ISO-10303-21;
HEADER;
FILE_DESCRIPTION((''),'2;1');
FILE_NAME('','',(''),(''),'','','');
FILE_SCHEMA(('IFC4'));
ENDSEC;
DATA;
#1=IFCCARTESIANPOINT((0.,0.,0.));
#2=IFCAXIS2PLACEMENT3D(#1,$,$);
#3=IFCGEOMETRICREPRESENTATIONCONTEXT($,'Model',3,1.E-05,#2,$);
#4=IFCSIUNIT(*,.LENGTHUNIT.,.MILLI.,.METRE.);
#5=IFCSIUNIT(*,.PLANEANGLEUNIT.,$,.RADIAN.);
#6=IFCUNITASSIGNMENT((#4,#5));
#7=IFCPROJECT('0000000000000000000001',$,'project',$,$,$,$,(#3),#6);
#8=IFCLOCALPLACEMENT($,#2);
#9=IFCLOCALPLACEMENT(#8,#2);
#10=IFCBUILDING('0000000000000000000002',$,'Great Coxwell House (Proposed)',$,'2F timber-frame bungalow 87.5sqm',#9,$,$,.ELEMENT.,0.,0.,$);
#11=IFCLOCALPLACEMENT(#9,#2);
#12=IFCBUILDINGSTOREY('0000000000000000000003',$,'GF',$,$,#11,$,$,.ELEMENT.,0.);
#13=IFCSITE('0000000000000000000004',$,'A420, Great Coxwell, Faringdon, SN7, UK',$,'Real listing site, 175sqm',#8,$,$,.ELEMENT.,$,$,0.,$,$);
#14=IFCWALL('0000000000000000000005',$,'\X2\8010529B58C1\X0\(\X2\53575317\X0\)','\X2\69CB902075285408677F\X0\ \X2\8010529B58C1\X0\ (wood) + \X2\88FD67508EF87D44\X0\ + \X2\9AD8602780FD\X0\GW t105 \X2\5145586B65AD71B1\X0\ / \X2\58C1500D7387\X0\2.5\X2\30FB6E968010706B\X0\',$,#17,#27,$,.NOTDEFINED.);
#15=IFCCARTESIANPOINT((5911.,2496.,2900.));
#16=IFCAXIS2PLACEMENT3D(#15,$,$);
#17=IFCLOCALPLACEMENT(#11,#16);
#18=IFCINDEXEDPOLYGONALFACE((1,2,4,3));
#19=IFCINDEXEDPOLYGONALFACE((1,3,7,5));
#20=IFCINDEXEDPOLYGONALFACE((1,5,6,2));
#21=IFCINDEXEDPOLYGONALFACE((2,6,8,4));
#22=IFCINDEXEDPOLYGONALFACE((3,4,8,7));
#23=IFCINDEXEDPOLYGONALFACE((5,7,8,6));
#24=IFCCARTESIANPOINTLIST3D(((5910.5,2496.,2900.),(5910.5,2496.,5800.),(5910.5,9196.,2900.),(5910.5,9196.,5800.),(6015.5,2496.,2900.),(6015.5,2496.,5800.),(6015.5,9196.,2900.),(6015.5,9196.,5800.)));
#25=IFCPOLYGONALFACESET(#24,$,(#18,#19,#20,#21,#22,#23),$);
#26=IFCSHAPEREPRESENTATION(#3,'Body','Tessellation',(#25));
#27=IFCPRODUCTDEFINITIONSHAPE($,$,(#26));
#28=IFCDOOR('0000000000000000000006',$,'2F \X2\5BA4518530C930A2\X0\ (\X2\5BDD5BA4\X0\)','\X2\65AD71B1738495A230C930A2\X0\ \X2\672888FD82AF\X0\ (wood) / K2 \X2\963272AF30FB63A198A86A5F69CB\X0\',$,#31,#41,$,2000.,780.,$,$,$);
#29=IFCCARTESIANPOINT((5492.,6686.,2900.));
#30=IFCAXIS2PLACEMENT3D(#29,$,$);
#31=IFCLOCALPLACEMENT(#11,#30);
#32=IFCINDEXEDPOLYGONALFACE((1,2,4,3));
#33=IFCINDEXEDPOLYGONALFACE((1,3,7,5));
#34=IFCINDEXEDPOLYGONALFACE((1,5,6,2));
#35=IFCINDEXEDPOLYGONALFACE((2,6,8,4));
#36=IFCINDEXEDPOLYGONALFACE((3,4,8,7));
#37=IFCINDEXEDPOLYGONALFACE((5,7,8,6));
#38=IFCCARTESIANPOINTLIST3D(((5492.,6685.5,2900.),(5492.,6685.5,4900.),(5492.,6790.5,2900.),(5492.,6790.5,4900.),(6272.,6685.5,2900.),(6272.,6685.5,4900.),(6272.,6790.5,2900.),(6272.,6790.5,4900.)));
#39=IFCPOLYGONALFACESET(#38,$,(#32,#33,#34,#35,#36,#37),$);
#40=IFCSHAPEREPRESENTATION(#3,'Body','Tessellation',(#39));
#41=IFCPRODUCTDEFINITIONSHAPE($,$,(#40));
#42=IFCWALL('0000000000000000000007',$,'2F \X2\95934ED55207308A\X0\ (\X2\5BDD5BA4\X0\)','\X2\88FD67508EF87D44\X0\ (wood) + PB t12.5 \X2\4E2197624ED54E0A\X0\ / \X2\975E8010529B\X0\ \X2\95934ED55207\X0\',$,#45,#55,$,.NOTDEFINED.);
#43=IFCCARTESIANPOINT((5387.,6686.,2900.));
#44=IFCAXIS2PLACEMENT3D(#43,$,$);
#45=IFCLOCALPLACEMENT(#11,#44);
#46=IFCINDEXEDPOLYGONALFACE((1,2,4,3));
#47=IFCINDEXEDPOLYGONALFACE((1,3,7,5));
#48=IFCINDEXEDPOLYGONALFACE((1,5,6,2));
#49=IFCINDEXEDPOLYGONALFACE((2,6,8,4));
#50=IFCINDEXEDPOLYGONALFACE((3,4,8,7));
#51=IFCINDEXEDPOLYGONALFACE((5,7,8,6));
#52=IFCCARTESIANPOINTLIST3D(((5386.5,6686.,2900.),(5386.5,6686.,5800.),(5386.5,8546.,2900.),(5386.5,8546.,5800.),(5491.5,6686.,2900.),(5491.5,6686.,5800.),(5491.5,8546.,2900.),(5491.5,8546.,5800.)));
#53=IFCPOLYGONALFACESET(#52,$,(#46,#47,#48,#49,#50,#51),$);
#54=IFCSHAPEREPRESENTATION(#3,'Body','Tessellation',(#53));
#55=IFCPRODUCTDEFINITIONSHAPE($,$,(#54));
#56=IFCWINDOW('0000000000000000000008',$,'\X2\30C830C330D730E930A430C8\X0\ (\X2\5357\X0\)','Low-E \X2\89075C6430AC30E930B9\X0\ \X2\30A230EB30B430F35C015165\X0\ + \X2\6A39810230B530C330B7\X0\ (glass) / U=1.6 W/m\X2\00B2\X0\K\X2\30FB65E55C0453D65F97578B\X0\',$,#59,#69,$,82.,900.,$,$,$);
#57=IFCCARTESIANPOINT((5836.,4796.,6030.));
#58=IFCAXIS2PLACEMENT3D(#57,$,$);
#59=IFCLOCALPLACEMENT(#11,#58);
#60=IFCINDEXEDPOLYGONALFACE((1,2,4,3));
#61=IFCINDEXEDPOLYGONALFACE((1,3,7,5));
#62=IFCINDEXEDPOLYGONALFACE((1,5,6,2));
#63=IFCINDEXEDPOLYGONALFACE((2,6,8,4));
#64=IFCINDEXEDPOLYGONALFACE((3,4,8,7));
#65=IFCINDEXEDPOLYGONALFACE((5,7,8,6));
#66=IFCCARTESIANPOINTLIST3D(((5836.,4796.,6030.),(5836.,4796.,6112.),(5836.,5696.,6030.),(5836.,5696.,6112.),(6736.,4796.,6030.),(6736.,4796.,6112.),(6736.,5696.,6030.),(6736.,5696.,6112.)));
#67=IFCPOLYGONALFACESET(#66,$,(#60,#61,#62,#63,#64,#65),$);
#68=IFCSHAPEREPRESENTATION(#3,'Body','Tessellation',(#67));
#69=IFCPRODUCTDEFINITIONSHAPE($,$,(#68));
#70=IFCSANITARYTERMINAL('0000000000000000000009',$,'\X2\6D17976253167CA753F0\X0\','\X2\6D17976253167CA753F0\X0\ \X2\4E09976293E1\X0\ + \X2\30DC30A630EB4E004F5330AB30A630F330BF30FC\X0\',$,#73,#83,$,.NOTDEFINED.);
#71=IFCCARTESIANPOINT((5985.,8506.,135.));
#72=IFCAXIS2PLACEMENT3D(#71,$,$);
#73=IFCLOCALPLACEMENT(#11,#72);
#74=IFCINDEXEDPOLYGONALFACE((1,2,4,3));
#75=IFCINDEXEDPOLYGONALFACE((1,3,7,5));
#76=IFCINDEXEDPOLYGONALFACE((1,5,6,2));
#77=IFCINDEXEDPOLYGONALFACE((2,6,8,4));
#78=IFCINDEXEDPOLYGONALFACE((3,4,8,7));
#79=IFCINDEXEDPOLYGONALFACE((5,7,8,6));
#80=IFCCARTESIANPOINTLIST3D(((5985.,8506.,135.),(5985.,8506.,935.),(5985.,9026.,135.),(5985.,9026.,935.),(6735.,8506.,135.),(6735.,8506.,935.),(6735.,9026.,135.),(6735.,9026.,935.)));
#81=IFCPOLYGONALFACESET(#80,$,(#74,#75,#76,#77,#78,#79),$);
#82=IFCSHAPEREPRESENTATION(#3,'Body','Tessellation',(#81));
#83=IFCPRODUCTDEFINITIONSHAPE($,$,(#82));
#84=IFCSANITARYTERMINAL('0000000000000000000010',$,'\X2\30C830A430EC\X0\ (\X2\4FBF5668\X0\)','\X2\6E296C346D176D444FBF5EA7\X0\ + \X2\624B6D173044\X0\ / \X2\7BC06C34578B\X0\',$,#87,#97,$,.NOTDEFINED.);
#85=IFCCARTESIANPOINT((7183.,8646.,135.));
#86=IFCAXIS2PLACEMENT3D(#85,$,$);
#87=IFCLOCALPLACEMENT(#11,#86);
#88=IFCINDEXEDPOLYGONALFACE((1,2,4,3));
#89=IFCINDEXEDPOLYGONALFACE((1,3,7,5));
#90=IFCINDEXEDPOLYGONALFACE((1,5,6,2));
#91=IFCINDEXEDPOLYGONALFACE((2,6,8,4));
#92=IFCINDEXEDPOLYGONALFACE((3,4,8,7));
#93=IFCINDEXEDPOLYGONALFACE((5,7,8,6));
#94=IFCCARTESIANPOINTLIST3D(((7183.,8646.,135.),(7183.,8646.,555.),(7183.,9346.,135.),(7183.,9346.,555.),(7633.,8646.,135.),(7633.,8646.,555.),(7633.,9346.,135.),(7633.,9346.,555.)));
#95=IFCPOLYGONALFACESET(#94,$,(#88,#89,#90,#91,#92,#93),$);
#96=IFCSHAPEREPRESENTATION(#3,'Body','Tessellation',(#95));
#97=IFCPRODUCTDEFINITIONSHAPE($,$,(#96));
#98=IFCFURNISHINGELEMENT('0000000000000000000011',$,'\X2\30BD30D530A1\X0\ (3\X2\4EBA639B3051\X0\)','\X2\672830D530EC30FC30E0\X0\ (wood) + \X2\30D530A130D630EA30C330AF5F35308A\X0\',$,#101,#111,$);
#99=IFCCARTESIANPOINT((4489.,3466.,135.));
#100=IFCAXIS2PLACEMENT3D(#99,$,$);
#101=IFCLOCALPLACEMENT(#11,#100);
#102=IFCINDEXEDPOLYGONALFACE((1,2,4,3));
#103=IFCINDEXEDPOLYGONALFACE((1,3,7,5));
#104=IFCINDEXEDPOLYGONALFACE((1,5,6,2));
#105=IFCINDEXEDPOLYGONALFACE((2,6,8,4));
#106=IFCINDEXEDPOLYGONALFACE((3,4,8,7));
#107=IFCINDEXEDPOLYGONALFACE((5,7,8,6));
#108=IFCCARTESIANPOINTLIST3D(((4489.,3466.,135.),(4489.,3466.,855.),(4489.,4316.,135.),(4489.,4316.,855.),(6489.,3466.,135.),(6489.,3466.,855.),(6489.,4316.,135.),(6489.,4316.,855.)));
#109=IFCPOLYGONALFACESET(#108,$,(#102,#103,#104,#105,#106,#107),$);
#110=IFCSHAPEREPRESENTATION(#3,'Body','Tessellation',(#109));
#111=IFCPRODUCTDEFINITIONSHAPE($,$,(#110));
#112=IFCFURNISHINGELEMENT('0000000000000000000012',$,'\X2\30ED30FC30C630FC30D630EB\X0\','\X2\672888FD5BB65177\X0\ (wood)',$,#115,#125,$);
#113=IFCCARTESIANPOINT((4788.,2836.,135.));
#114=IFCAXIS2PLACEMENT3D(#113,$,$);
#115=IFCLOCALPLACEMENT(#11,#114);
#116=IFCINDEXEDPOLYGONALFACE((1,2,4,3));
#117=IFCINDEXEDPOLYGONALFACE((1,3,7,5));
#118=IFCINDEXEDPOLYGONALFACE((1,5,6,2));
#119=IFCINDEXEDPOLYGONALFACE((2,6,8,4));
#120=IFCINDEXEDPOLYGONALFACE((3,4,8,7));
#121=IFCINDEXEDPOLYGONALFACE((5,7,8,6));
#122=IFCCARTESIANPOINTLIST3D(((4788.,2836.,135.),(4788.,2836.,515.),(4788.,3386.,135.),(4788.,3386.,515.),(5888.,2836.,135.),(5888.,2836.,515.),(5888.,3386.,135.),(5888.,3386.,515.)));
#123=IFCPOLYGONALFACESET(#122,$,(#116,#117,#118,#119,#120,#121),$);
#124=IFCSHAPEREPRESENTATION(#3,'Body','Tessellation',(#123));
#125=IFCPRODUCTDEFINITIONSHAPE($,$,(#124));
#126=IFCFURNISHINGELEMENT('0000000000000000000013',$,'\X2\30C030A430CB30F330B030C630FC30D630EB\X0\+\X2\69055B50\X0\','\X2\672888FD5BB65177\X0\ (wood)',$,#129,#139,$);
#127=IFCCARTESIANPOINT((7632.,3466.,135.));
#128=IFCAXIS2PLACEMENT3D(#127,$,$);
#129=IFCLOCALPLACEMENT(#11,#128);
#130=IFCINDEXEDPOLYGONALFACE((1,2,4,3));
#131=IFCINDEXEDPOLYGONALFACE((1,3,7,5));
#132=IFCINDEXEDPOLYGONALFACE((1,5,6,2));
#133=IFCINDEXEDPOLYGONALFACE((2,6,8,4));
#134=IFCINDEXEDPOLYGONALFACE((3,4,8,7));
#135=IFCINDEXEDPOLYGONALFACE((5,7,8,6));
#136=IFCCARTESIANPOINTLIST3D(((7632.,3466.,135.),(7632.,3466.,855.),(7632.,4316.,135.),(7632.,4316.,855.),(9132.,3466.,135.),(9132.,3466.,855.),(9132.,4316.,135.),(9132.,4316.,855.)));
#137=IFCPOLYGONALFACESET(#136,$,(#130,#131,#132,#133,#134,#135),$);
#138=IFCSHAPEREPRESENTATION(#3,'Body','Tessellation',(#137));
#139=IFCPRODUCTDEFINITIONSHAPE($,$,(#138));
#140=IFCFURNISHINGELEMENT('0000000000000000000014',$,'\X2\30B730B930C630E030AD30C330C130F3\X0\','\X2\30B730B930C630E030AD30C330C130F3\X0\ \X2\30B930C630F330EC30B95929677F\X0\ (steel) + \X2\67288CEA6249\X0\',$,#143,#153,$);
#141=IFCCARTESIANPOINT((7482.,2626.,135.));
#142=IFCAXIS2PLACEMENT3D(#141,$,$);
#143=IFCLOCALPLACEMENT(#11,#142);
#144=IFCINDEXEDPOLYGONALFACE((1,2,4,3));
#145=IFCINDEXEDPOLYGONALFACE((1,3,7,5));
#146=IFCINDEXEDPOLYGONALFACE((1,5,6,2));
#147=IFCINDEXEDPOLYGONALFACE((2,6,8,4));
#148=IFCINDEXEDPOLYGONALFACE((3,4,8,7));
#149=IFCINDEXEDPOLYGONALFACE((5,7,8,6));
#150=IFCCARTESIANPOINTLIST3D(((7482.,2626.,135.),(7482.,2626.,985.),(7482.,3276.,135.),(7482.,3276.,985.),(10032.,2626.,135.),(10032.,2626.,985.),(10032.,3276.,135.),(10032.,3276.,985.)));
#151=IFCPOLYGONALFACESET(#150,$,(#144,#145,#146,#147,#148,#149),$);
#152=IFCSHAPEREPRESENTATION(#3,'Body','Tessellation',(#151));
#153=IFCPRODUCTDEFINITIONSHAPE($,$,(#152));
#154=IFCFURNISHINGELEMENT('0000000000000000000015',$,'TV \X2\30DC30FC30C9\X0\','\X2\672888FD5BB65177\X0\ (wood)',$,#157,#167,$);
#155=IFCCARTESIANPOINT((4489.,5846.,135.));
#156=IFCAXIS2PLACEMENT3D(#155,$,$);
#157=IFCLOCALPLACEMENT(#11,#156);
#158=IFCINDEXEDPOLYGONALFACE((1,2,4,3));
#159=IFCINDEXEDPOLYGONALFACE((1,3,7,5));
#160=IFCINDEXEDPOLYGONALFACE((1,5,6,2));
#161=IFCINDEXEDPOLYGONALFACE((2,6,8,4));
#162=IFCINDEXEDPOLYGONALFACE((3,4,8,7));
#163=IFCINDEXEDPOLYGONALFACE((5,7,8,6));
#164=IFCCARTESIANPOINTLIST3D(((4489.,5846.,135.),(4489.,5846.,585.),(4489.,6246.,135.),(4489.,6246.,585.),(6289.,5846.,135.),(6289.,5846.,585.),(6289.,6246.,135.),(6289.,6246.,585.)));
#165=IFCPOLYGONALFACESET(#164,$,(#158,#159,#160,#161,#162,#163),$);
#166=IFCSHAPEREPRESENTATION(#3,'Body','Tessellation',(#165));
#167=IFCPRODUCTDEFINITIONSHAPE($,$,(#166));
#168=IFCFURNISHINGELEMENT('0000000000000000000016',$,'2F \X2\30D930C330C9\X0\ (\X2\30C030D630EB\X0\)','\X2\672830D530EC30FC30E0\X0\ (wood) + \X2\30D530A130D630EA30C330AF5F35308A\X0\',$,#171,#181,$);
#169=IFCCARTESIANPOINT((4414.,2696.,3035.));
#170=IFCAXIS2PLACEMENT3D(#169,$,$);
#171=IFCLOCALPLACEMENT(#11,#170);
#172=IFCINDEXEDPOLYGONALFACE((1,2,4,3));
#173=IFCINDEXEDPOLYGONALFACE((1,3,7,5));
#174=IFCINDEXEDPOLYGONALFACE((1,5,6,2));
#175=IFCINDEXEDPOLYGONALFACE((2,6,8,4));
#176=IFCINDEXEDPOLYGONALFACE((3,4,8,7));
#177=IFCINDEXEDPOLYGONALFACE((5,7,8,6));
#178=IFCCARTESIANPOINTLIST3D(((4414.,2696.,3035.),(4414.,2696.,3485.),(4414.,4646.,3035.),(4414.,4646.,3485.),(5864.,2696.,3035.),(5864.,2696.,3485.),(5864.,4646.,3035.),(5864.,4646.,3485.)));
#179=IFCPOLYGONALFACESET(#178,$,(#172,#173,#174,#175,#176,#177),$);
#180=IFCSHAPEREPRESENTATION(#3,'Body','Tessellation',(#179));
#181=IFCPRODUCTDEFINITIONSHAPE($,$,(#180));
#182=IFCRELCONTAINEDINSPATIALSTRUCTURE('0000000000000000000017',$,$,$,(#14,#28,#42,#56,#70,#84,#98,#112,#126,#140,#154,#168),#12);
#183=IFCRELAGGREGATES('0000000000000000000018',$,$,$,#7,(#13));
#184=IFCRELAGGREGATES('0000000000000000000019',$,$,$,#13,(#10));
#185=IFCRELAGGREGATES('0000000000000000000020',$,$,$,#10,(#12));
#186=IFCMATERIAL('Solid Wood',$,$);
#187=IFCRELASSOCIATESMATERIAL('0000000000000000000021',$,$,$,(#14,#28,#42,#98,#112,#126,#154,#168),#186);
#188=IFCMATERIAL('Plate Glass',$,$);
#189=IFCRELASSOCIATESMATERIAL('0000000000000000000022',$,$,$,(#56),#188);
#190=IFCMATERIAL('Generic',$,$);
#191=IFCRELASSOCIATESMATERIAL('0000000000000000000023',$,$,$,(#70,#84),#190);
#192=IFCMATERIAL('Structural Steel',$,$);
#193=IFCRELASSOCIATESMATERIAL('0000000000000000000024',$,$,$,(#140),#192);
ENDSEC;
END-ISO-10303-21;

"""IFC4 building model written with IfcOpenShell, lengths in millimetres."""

from ifc_helpers import new_model, si_unit, frame, frame_2d, origin, place, context, project, spatial, rectangle, extrude, material, element, fill, save


model = new_model("IFC4")

# Units and contexts
model_context = context("Model", 3, precision=1e-05, world=origin())
ifc_project = project(units=[si_unit("LENGTHUNIT", "METRE", prefix="MILLI"), si_unit("PLANEANGLEUNIT", "RADIAN")], contexts=[model_context])

# Site, building, storey
site_placement = place(None, origin())
site = spatial("IfcSite", under=ifc_project, at=site_placement, Name="A420, Great Coxwell, Faringdon, SN7, UK", ObjectType="Real listing site, 175sqm", CompositionType="ELEMENT", RefElevation=0.0)
building_placement = place(site_placement, origin())
building = spatial("IfcBuilding", under=site, at=building_placement, Name="Great Coxwell House (Proposed)", ObjectType="2F timber-frame bungalow 87.5sqm", CompositionType="ELEMENT", ElevationOfRefHeight=0.0, ElevationOfTerrain=0.0)
storey_placement = place(building_placement, origin())
storey = spatial("IfcBuildingStorey", under=building, at=storey_placement, Name="GF", CompositionType="ELEMENT", Elevation=0.0)

# Shared definitions
ifc_material_1 = material(Name="Solid Wood")

# Wall, opening, door
wall_1_placement = place(storey_placement, frame((5911.0, 2496.0, 2900.0)))
wall_1 = element("IfcWall", 1, at=wall_1_placement, inside=storey, material=ifc_material_1, Name="耐力壁(南北)", Description="構造用合板 耐力壁 (wood) + 製材軸組 + 高性能GW t105 充填断熱 / 壁倍率2.5・準耐火", PredefinedType="NOTDEFINED", context=model_context, shape_type="SweptSolid", body=[
    extrude(rectangle(XDim=105.0, YDim=6700.0, at=frame_2d((52.0, 3350.0))), frame((5911.0, 2496.0, 2900.0)), (0.0, 0.0, 1.0), 2900.0),
])
opening_1_placement = place(storey_placement, frame((5492.0, 6686.0, 2900.0)))
opening_1 = element("IfcOpeningElement", 2, at=opening_1_placement, cuts=wall_1, PredefinedType="NOTDEFINED", context=model_context, shape_type="SweptSolid", body=[
    extrude(rectangle(XDim=780.0, YDim=105.0, at=frame_2d((390.0, 52.0))), frame((5492.0, 6686.0, 2900.0)), (0.0, 0.0, 1.0), 2000.0),
])
door_1_placement = place(storey_placement, frame((5492.0, 6686.0, 2900.0)))
door_1 = element("IfcDoor", 3, at=door_1_placement, inside=storey, material=ifc_material_1, Name="2F 室内ドア (寝室)", Description="断熱玄関ドア 木製芯 (wood) / K2 防犯・採風機構", OverallHeight=2000.0, OverallWidth=780.0, context=model_context, shape_type="SweptSolid", body=[
    extrude(rectangle(XDim=780.0, YDim=105.0, at=frame_2d((390.0, 52.0))), frame((5492.0, 6686.0, 2900.0)), (0.0, 0.0, 1.0), 2000.0),
])
fill(opening_1, door_1)

# Wall
wall_2_placement = place(storey_placement, frame((5387.0, 6686.0, 2900.0)))
element("IfcWall", 4, at=wall_2_placement, inside=storey, material=ifc_material_1, Name="2F 間仕切り (寝室)", Description="製材軸組 (wood) + PB t12.5 両面仕上 / 非耐力 間仕切", PredefinedType="NOTDEFINED", context=model_context, shape_type="SweptSolid", body=[
    extrude(rectangle(XDim=105.0, YDim=1860.0, at=frame_2d((52.0, 930.0))), frame((5387.0, 6686.0, 2900.0)), (0.0, 0.0, 1.0), 2900.0),
])

# Window
ifc_material_2 = material(Name="Plate Glass")
window_placement = place(storey_placement, frame((5836.0, 4796.0, 6030.0)))
element("IfcWindow", 5, at=window_placement, inside=storey, material=ifc_material_2, Name="トップライト (南)", Description="Low-E 複層ガラス アルゴン封入 + 樹脂サッシ (glass) / U=1.6 W/m²K・日射取得型", OverallHeight=82.0, OverallWidth=900.0, context=model_context, shape_type="SweptSolid", body=[
    extrude(rectangle(XDim=900.0, YDim=900.0, at=frame_2d((450.0, 450.0))), frame((5836.0, 4796.0, 6030.0)), (0.0, 0.0, 1.0), 82.0),
])

# Sanitary terminals
ifc_material_3 = material(Name="Generic")
sanitary_terminal_1_placement = place(storey_placement, frame((5985.0, 8506.0, 135.0)))
element("IfcSanitaryTerminal", 6, at=sanitary_terminal_1_placement, inside=storey, material=ifc_material_3, Name="洗面化粧台", Description="洗面化粧台 三面鏡 + ボウル一体カウンター", PredefinedType="NOTDEFINED", context=model_context, shape_type="SweptSolid", body=[
    extrude(rectangle(XDim=750.0, YDim=520.0, at=frame_2d((375.0, 260.0))), frame((5985.0, 8506.0, 135.0)), (0.0, 0.0, 1.0), 800.0),
])
sanitary_terminal_2_placement = place(storey_placement, frame((7183.0, 8646.0, 135.0)))
element("IfcSanitaryTerminal", 7, at=sanitary_terminal_2_placement, inside=storey, material=ifc_material_3, Name="トイレ (便器)", Description="温水洗浄便座 + 手洗い / 節水型", PredefinedType="NOTDEFINED", context=model_context, shape_type="SweptSolid", body=[
    extrude(rectangle(XDim=450.0, YDim=700.0, at=frame_2d((225.0, 350.0))), frame((7183.0, 8646.0, 135.0)), (0.0, 0.0, 1.0), 420.0),
])

# Furnishing elements
furnishing_1_placement = place(storey_placement, frame((4489.0, 3466.0, 135.0)))
element("IfcFurnishingElement", 8, at=furnishing_1_placement, inside=storey, material=ifc_material_1, Name="ソファ (3人掛け)", Description="木フレーム (wood) + ファブリック張り", context=model_context, shape_type="SweptSolid", body=[
    extrude(rectangle(XDim=2000.0, YDim=850.0, at=frame_2d((1000.0, 425.0))), frame((4489.0, 3466.0, 135.0)), (0.0, 0.0, 1.0), 720.0),
])
furnishing_2_placement = place(storey_placement, frame((4788.0, 2836.0, 135.0)))
element("IfcFurnishingElement", 9, at=furnishing_2_placement, inside=storey, material=ifc_material_1, Name="ローテーブル", Description="木製家具 (wood)", context=model_context, shape_type="SweptSolid", body=[
    extrude(rectangle(XDim=1100.0, YDim=550.0, at=frame_2d((550.0, 275.0))), frame((4788.0, 2836.0, 135.0)), (0.0, 0.0, 1.0), 380.0),
])
furnishing_3_placement = place(storey_placement, frame((7632.0, 3466.0, 135.0)))
element("IfcFurnishingElement", 10, at=furnishing_3_placement, inside=storey, material=ifc_material_1, Name="ダイニングテーブル+椅子", Description="木製家具 (wood)", context=model_context, shape_type="SweptSolid", body=[
    extrude(rectangle(XDim=1500.0, YDim=850.0, at=frame_2d((750.0, 425.0))), frame((7632.0, 3466.0, 135.0)), (0.0, 0.0, 1.0), 720.0),
])
ifc_material_4 = material(Name="Structural Steel")
furnishing_4_placement = place(storey_placement, frame((7482.0, 2626.0, 135.0)))
element("IfcFurnishingElement", 11, at=furnishing_4_placement, inside=storey, material=ifc_material_4, Name="システムキッチン", Description="システムキッチン ステンレス天板 (steel) + 木質扉", context=model_context, shape_type="SweptSolid", body=[
    extrude(rectangle(XDim=2550.0, YDim=650.0, at=frame_2d((1275.0, 325.0))), frame((7482.0, 2626.0, 135.0)), (0.0, 0.0, 1.0), 850.0),
])
furnishing_5_placement = place(storey_placement, frame((4489.0, 5846.0, 135.0)))
element("IfcFurnishingElement", 12, at=furnishing_5_placement, inside=storey, material=ifc_material_1, Name="TV ボード", Description="木製家具 (wood)", context=model_context, shape_type="SweptSolid", body=[
    extrude(rectangle(XDim=1800.0, YDim=400.0, at=frame_2d((900.0, 200.0))), frame((4489.0, 5846.0, 135.0)), (0.0, 0.0, 1.0), 450.0),
])
furnishing_6_placement = place(storey_placement, frame((4414.0, 2696.0, 3035.0)))
element("IfcFurnishingElement", 13, at=furnishing_6_placement, inside=storey, material=ifc_material_1, Name="2F ベッド (ダブル)", Description="木フレーム (wood) + ファブリック張り", context=model_context, shape_type="SweptSolid", body=[
    extrude(rectangle(XDim=1450.0, YDim=1950.0, at=frame_2d((725.0, 975.0))), frame((4414.0, 2696.0, 3035.0)), (0.0, 0.0, 1.0), 450.0),
])

save(model, "model.ifc")
